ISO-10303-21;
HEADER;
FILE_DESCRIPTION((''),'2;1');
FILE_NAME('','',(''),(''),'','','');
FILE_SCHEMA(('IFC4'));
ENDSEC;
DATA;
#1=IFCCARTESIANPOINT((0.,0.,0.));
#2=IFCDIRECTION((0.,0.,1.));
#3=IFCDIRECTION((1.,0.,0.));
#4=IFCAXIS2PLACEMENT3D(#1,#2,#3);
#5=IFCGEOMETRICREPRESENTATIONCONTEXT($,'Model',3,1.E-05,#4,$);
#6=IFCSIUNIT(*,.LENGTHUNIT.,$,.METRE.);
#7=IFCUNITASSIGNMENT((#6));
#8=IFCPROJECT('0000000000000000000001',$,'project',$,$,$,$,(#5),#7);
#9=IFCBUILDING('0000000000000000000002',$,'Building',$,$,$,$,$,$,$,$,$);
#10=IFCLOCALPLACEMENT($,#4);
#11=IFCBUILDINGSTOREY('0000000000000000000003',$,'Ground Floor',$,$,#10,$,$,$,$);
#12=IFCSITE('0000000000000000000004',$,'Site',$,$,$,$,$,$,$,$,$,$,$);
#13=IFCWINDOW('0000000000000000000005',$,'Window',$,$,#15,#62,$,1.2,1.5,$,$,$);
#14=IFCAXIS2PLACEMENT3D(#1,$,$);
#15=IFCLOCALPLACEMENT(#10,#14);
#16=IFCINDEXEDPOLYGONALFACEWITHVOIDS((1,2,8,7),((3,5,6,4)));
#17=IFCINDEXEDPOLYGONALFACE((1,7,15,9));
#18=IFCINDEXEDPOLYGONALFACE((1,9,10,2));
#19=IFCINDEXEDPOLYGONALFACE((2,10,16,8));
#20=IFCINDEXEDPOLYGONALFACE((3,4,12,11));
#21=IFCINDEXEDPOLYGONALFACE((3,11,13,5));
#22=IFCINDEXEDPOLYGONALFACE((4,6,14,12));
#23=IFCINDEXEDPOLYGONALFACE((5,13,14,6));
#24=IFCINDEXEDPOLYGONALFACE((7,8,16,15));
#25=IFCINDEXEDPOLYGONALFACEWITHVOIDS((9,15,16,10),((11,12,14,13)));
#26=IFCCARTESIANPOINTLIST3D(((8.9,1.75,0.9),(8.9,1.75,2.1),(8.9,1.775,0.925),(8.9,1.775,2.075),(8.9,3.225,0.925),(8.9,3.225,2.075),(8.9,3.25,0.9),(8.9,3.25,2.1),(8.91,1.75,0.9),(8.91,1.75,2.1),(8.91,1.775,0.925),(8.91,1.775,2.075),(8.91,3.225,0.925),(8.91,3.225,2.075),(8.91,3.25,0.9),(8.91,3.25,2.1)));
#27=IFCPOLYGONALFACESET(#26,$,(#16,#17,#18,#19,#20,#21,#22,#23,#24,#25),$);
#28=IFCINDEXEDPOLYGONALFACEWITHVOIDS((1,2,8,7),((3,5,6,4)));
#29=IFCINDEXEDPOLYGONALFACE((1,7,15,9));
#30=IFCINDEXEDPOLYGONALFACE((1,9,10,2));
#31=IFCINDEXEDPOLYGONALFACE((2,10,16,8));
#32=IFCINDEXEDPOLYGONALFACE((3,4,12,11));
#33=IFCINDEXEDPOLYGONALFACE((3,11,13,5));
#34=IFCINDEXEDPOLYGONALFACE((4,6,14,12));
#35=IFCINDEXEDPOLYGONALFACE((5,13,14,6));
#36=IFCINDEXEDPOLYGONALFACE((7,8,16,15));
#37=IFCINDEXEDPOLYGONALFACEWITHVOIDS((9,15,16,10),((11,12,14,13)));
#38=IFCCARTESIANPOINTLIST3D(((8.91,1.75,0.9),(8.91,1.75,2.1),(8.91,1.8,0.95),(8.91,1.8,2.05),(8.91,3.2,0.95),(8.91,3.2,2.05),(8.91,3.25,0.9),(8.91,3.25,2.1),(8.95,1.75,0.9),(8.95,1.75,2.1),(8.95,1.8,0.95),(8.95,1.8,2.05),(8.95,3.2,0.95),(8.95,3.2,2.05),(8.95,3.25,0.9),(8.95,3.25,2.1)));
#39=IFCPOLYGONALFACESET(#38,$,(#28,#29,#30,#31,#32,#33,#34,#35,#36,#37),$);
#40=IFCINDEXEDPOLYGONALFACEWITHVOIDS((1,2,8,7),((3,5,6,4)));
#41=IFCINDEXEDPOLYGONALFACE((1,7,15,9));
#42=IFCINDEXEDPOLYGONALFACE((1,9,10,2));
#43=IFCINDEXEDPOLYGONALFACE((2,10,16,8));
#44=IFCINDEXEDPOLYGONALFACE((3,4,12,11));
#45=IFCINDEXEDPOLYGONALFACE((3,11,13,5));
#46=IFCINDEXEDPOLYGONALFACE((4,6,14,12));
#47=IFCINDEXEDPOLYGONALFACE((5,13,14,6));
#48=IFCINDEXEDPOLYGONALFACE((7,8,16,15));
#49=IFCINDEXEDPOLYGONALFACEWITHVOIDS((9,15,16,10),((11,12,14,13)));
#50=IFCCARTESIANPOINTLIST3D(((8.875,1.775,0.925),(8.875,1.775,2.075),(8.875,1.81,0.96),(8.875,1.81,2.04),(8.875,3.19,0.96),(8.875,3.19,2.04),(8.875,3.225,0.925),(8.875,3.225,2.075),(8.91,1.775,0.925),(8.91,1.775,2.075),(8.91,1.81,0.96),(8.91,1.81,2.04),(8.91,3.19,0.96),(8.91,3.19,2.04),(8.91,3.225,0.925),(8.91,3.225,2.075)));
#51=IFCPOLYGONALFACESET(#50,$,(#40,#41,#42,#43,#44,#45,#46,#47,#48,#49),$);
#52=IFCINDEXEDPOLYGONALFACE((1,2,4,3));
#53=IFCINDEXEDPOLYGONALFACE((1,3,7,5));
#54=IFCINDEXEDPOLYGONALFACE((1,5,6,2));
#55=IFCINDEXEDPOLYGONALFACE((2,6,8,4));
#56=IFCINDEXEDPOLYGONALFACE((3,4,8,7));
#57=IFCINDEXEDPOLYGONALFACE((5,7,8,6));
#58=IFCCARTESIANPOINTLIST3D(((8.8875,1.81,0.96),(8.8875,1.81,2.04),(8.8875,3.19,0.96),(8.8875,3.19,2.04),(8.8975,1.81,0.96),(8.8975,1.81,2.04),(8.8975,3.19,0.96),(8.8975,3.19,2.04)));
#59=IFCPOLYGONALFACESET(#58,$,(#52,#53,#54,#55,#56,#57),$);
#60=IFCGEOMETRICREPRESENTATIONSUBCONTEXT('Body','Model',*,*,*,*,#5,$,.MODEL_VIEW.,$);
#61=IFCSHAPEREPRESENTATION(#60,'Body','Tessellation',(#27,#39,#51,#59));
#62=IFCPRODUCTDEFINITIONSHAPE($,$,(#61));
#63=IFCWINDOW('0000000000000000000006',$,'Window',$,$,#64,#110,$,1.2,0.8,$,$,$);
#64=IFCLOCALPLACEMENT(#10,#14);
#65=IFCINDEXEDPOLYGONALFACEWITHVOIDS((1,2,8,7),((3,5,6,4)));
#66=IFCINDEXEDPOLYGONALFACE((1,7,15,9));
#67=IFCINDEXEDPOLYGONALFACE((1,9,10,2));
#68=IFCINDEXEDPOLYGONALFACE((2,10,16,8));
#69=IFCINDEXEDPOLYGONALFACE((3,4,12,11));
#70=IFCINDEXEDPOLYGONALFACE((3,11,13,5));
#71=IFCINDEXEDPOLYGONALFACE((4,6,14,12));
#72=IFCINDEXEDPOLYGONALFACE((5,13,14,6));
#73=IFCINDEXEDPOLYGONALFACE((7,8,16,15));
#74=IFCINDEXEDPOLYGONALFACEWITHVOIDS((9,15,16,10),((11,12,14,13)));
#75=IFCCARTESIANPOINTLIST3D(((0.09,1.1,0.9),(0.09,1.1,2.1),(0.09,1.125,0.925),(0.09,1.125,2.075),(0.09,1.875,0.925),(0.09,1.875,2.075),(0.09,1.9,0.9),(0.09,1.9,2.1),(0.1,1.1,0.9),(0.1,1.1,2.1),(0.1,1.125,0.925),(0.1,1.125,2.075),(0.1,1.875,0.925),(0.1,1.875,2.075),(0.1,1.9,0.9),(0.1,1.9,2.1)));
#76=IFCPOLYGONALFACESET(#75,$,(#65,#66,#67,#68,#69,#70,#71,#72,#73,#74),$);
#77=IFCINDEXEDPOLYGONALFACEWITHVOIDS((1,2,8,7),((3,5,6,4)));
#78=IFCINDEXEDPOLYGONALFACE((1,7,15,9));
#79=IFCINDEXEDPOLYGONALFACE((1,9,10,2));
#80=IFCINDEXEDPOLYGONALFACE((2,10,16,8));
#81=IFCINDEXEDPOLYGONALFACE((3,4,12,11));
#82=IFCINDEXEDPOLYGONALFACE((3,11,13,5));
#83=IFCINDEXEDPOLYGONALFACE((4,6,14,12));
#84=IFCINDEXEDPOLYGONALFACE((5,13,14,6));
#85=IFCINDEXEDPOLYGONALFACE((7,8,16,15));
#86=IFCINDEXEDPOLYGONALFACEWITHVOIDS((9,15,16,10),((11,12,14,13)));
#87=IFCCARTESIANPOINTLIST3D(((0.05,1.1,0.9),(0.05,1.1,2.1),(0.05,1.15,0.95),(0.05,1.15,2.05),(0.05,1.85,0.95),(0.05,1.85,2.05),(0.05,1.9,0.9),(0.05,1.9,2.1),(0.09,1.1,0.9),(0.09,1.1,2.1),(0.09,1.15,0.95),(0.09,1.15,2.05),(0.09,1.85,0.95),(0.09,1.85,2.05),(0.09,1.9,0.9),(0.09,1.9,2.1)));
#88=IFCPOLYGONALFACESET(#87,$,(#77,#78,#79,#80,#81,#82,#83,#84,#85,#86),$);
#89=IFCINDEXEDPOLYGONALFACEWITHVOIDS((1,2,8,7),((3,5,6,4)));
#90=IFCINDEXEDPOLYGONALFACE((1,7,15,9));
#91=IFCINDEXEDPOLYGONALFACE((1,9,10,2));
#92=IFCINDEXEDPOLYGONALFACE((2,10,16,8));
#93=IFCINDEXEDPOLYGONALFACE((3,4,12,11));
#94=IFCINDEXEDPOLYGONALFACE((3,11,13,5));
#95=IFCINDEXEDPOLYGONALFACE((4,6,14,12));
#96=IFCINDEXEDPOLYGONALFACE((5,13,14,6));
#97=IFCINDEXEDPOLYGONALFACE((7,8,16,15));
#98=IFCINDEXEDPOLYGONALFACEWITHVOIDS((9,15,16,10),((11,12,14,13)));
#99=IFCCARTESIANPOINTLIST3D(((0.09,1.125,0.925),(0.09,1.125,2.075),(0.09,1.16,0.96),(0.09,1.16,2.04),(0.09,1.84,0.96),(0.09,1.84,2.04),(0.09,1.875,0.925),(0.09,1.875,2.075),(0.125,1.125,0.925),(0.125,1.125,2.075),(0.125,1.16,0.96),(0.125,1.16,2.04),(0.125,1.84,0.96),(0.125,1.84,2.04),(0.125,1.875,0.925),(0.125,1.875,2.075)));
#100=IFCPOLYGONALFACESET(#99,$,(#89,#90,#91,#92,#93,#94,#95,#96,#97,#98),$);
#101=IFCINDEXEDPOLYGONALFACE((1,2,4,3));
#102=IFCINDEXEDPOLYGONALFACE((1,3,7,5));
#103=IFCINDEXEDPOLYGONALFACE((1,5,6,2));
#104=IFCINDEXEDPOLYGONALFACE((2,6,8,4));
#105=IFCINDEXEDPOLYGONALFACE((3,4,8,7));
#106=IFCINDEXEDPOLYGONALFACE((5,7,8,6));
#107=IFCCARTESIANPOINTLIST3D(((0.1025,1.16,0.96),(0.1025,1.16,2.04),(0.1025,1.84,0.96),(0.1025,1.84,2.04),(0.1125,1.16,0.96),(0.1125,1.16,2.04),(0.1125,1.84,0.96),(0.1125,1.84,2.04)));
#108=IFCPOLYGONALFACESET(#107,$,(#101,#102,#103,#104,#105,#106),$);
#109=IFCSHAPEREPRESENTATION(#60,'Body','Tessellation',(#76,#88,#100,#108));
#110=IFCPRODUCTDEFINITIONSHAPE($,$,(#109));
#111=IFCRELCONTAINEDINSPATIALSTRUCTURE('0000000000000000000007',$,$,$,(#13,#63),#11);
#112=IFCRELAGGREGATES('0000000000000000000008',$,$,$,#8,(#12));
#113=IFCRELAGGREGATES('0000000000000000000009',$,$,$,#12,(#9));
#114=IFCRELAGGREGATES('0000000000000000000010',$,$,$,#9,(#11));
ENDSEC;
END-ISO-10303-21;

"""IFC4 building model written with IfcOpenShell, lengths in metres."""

from ifc_helpers import new_model, si_unit, frame, origin_with_axes, place, context, subcontext, project, spatial, line, indexed_curve, outline, extrude, element, save


model = new_model("IFC4")

# Units and contexts
model_context = context("Model", 3, precision=1e-05, world=origin_with_axes())
body_context = subcontext(model_context, "Body", "Model", "MODEL_VIEW")
ifc_project = project(units=[si_unit("LENGTHUNIT", "METRE")], contexts=[model_context])

# Site, building, storey
site = spatial("IfcSite", under=ifc_project, Name="Site")
building = spatial("IfcBuilding", under=site, Name="Building")
storey_placement = place(None, origin_with_axes())
storey = spatial("IfcBuildingStorey", under=building, at=storey_placement, Name="Ground Floor")

# Windows
for number, where, z_axis, x_axis, name in (
    (1, (9.0, 1.75, 0.9), (0.0, 0.0, 1.0), (0.0, 1.0, 0.0), "Window"),
):
    element("IfcWindow", number, at=place(storey_placement, frame(where, z_axis=z_axis, x_axis=x_axis)), inside=storey, Name=name, OverallHeight=1.2, OverallWidth=1.5, context=body_context, shape_type="SweptSolid", body=[
        extrude(outline(indexed_curve([(0.0, 0.0), (1.5, 0.0), (1.5, 1.2), (0.0, 1.2)], segments=[line(1, 2, 3, 4, 1)]), holes=[indexed_curve([(0.025, 0.025), (1.475, 0.025), (1.475, 1.175), (0.025, 1.175)], segments=[line(1, 2, 3, 4, 1)])]), frame((0.0, 0.09, 0.0), z_axis=(0.0, -1.0, 0.0), x_axis=(1.0, 0.0, 0.0)), (0.0, 0.0, -1.0), 0.01),
        extrude(outline(indexed_curve([(0.0, 0.0), (1.5, 0.0), (1.5, 1.2), (0.0, 1.2)], segments=[line(1, 2, 3, 4, 1)]), holes=[indexed_curve([(0.05, 0.05), (1.45, 0.05), (1.45, 1.15), (0.05, 1.15)], segments=[line(1, 2, 3, 4, 1)])]), frame((0.0, 0.05, 0.0), z_axis=(0.0, -1.0, 0.0), x_axis=(1.0, 0.0, 0.0)), (0.0, 0.0, -1.0), 0.04),
        extrude(outline(indexed_curve([(0.0, 0.0), (1.45, 0.0), (1.45, 1.15), (0.0, 1.15)], segments=[line(1, 2, 3, 4, 1)]), holes=[indexed_curve([(0.035, 0.035), (1.415, 0.035), (1.415, 1.115), (0.035, 1.115)], segments=[line(1, 2, 3, 4, 1)])]), frame((0.025, 0.09, 0.025), z_axis=(0.0, -1.0, 0.0), x_axis=(1.0, 0.0, 0.0)), (0.0, 0.0, -1.0), 0.035),
        extrude(outline(indexed_curve([(0.035, 0.035), (1.415, 0.035), (1.415, 1.115), (0.035, 1.115)], segments=[line(1, 2, 3, 4, 1)])), frame((0.025, 0.1025, 0.025), z_axis=(0.0, -1.0, 0.0), x_axis=(1.0, 0.0, 0.0)), (0.0, 0.0, -1.0), 0.01),
    ])
window_1_placement = place(storey_placement, frame((0.0, 1.9, 0.9), z_axis=(0.0, 0.0, 1.0), x_axis=(0.0, -1.0, 0.0)))
element("IfcWindow", 2, at=window_1_placement, inside=storey, Name="Window", OverallHeight=1.2, OverallWidth=0.8, context=body_context, shape_type="SweptSolid", body=[
    extrude(outline(indexed_curve([(0.0, 0.0), (0.8, 0.0), (0.8, 1.2), (0.0, 1.2)], segments=[line(1, 2, 3, 4, 1)]), holes=[indexed_curve([(0.025, 0.025), (0.775, 0.025), (0.775, 1.175), (0.025, 1.175)], segments=[line(1, 2, 3, 4, 1)])]), frame((0.0, 0.09, 0.0), z_axis=(0.0, -1.0, 0.0), x_axis=(1.0, 0.0, 0.0)), (0.0, 0.0, -1.0), 0.01),
    extrude(outline(indexed_curve([(0.0, 0.0), (0.8, 0.0), (0.8, 1.2), (0.0, 1.2)], segments=[line(1, 2, 3, 4, 1)]), holes=[indexed_curve([(0.05, 0.05), (0.75, 0.05), (0.75, 1.15), (0.05, 1.15)], segments=[line(1, 2, 3, 4, 1)])]), frame((0.0, 0.05, 0.0), z_axis=(0.0, -1.0, 0.0), x_axis=(1.0, 0.0, 0.0)), (0.0, 0.0, -1.0), 0.04),
    extrude(outline(indexed_curve([(0.0, 0.0), (0.75, 0.0), (0.75, 1.15), (0.0, 1.15)], segments=[line(1, 2, 3, 4, 1)]), holes=[indexed_curve([(0.035, 0.035), (0.715, 0.035), (0.715, 1.115), (0.035, 1.115)], segments=[line(1, 2, 3, 4, 1)])]), frame((0.025, 0.09, 0.025), z_axis=(0.0, -1.0, 0.0), x_axis=(1.0, 0.0, 0.0)), (0.0, 0.0, -1.0), 0.035),
    extrude(outline(indexed_curve([(0.035, 0.035), (0.715, 0.035), (0.715, 1.115), (0.035, 1.115)], segments=[line(1, 2, 3, 4, 1)])), frame((0.025, 0.1025, 0.025), z_axis=(0.0, -1.0, 0.0), x_axis=(1.0, 0.0, 0.0)), (0.0, 0.0, -1.0), 0.01),
])

save(model, "model.ifc")
